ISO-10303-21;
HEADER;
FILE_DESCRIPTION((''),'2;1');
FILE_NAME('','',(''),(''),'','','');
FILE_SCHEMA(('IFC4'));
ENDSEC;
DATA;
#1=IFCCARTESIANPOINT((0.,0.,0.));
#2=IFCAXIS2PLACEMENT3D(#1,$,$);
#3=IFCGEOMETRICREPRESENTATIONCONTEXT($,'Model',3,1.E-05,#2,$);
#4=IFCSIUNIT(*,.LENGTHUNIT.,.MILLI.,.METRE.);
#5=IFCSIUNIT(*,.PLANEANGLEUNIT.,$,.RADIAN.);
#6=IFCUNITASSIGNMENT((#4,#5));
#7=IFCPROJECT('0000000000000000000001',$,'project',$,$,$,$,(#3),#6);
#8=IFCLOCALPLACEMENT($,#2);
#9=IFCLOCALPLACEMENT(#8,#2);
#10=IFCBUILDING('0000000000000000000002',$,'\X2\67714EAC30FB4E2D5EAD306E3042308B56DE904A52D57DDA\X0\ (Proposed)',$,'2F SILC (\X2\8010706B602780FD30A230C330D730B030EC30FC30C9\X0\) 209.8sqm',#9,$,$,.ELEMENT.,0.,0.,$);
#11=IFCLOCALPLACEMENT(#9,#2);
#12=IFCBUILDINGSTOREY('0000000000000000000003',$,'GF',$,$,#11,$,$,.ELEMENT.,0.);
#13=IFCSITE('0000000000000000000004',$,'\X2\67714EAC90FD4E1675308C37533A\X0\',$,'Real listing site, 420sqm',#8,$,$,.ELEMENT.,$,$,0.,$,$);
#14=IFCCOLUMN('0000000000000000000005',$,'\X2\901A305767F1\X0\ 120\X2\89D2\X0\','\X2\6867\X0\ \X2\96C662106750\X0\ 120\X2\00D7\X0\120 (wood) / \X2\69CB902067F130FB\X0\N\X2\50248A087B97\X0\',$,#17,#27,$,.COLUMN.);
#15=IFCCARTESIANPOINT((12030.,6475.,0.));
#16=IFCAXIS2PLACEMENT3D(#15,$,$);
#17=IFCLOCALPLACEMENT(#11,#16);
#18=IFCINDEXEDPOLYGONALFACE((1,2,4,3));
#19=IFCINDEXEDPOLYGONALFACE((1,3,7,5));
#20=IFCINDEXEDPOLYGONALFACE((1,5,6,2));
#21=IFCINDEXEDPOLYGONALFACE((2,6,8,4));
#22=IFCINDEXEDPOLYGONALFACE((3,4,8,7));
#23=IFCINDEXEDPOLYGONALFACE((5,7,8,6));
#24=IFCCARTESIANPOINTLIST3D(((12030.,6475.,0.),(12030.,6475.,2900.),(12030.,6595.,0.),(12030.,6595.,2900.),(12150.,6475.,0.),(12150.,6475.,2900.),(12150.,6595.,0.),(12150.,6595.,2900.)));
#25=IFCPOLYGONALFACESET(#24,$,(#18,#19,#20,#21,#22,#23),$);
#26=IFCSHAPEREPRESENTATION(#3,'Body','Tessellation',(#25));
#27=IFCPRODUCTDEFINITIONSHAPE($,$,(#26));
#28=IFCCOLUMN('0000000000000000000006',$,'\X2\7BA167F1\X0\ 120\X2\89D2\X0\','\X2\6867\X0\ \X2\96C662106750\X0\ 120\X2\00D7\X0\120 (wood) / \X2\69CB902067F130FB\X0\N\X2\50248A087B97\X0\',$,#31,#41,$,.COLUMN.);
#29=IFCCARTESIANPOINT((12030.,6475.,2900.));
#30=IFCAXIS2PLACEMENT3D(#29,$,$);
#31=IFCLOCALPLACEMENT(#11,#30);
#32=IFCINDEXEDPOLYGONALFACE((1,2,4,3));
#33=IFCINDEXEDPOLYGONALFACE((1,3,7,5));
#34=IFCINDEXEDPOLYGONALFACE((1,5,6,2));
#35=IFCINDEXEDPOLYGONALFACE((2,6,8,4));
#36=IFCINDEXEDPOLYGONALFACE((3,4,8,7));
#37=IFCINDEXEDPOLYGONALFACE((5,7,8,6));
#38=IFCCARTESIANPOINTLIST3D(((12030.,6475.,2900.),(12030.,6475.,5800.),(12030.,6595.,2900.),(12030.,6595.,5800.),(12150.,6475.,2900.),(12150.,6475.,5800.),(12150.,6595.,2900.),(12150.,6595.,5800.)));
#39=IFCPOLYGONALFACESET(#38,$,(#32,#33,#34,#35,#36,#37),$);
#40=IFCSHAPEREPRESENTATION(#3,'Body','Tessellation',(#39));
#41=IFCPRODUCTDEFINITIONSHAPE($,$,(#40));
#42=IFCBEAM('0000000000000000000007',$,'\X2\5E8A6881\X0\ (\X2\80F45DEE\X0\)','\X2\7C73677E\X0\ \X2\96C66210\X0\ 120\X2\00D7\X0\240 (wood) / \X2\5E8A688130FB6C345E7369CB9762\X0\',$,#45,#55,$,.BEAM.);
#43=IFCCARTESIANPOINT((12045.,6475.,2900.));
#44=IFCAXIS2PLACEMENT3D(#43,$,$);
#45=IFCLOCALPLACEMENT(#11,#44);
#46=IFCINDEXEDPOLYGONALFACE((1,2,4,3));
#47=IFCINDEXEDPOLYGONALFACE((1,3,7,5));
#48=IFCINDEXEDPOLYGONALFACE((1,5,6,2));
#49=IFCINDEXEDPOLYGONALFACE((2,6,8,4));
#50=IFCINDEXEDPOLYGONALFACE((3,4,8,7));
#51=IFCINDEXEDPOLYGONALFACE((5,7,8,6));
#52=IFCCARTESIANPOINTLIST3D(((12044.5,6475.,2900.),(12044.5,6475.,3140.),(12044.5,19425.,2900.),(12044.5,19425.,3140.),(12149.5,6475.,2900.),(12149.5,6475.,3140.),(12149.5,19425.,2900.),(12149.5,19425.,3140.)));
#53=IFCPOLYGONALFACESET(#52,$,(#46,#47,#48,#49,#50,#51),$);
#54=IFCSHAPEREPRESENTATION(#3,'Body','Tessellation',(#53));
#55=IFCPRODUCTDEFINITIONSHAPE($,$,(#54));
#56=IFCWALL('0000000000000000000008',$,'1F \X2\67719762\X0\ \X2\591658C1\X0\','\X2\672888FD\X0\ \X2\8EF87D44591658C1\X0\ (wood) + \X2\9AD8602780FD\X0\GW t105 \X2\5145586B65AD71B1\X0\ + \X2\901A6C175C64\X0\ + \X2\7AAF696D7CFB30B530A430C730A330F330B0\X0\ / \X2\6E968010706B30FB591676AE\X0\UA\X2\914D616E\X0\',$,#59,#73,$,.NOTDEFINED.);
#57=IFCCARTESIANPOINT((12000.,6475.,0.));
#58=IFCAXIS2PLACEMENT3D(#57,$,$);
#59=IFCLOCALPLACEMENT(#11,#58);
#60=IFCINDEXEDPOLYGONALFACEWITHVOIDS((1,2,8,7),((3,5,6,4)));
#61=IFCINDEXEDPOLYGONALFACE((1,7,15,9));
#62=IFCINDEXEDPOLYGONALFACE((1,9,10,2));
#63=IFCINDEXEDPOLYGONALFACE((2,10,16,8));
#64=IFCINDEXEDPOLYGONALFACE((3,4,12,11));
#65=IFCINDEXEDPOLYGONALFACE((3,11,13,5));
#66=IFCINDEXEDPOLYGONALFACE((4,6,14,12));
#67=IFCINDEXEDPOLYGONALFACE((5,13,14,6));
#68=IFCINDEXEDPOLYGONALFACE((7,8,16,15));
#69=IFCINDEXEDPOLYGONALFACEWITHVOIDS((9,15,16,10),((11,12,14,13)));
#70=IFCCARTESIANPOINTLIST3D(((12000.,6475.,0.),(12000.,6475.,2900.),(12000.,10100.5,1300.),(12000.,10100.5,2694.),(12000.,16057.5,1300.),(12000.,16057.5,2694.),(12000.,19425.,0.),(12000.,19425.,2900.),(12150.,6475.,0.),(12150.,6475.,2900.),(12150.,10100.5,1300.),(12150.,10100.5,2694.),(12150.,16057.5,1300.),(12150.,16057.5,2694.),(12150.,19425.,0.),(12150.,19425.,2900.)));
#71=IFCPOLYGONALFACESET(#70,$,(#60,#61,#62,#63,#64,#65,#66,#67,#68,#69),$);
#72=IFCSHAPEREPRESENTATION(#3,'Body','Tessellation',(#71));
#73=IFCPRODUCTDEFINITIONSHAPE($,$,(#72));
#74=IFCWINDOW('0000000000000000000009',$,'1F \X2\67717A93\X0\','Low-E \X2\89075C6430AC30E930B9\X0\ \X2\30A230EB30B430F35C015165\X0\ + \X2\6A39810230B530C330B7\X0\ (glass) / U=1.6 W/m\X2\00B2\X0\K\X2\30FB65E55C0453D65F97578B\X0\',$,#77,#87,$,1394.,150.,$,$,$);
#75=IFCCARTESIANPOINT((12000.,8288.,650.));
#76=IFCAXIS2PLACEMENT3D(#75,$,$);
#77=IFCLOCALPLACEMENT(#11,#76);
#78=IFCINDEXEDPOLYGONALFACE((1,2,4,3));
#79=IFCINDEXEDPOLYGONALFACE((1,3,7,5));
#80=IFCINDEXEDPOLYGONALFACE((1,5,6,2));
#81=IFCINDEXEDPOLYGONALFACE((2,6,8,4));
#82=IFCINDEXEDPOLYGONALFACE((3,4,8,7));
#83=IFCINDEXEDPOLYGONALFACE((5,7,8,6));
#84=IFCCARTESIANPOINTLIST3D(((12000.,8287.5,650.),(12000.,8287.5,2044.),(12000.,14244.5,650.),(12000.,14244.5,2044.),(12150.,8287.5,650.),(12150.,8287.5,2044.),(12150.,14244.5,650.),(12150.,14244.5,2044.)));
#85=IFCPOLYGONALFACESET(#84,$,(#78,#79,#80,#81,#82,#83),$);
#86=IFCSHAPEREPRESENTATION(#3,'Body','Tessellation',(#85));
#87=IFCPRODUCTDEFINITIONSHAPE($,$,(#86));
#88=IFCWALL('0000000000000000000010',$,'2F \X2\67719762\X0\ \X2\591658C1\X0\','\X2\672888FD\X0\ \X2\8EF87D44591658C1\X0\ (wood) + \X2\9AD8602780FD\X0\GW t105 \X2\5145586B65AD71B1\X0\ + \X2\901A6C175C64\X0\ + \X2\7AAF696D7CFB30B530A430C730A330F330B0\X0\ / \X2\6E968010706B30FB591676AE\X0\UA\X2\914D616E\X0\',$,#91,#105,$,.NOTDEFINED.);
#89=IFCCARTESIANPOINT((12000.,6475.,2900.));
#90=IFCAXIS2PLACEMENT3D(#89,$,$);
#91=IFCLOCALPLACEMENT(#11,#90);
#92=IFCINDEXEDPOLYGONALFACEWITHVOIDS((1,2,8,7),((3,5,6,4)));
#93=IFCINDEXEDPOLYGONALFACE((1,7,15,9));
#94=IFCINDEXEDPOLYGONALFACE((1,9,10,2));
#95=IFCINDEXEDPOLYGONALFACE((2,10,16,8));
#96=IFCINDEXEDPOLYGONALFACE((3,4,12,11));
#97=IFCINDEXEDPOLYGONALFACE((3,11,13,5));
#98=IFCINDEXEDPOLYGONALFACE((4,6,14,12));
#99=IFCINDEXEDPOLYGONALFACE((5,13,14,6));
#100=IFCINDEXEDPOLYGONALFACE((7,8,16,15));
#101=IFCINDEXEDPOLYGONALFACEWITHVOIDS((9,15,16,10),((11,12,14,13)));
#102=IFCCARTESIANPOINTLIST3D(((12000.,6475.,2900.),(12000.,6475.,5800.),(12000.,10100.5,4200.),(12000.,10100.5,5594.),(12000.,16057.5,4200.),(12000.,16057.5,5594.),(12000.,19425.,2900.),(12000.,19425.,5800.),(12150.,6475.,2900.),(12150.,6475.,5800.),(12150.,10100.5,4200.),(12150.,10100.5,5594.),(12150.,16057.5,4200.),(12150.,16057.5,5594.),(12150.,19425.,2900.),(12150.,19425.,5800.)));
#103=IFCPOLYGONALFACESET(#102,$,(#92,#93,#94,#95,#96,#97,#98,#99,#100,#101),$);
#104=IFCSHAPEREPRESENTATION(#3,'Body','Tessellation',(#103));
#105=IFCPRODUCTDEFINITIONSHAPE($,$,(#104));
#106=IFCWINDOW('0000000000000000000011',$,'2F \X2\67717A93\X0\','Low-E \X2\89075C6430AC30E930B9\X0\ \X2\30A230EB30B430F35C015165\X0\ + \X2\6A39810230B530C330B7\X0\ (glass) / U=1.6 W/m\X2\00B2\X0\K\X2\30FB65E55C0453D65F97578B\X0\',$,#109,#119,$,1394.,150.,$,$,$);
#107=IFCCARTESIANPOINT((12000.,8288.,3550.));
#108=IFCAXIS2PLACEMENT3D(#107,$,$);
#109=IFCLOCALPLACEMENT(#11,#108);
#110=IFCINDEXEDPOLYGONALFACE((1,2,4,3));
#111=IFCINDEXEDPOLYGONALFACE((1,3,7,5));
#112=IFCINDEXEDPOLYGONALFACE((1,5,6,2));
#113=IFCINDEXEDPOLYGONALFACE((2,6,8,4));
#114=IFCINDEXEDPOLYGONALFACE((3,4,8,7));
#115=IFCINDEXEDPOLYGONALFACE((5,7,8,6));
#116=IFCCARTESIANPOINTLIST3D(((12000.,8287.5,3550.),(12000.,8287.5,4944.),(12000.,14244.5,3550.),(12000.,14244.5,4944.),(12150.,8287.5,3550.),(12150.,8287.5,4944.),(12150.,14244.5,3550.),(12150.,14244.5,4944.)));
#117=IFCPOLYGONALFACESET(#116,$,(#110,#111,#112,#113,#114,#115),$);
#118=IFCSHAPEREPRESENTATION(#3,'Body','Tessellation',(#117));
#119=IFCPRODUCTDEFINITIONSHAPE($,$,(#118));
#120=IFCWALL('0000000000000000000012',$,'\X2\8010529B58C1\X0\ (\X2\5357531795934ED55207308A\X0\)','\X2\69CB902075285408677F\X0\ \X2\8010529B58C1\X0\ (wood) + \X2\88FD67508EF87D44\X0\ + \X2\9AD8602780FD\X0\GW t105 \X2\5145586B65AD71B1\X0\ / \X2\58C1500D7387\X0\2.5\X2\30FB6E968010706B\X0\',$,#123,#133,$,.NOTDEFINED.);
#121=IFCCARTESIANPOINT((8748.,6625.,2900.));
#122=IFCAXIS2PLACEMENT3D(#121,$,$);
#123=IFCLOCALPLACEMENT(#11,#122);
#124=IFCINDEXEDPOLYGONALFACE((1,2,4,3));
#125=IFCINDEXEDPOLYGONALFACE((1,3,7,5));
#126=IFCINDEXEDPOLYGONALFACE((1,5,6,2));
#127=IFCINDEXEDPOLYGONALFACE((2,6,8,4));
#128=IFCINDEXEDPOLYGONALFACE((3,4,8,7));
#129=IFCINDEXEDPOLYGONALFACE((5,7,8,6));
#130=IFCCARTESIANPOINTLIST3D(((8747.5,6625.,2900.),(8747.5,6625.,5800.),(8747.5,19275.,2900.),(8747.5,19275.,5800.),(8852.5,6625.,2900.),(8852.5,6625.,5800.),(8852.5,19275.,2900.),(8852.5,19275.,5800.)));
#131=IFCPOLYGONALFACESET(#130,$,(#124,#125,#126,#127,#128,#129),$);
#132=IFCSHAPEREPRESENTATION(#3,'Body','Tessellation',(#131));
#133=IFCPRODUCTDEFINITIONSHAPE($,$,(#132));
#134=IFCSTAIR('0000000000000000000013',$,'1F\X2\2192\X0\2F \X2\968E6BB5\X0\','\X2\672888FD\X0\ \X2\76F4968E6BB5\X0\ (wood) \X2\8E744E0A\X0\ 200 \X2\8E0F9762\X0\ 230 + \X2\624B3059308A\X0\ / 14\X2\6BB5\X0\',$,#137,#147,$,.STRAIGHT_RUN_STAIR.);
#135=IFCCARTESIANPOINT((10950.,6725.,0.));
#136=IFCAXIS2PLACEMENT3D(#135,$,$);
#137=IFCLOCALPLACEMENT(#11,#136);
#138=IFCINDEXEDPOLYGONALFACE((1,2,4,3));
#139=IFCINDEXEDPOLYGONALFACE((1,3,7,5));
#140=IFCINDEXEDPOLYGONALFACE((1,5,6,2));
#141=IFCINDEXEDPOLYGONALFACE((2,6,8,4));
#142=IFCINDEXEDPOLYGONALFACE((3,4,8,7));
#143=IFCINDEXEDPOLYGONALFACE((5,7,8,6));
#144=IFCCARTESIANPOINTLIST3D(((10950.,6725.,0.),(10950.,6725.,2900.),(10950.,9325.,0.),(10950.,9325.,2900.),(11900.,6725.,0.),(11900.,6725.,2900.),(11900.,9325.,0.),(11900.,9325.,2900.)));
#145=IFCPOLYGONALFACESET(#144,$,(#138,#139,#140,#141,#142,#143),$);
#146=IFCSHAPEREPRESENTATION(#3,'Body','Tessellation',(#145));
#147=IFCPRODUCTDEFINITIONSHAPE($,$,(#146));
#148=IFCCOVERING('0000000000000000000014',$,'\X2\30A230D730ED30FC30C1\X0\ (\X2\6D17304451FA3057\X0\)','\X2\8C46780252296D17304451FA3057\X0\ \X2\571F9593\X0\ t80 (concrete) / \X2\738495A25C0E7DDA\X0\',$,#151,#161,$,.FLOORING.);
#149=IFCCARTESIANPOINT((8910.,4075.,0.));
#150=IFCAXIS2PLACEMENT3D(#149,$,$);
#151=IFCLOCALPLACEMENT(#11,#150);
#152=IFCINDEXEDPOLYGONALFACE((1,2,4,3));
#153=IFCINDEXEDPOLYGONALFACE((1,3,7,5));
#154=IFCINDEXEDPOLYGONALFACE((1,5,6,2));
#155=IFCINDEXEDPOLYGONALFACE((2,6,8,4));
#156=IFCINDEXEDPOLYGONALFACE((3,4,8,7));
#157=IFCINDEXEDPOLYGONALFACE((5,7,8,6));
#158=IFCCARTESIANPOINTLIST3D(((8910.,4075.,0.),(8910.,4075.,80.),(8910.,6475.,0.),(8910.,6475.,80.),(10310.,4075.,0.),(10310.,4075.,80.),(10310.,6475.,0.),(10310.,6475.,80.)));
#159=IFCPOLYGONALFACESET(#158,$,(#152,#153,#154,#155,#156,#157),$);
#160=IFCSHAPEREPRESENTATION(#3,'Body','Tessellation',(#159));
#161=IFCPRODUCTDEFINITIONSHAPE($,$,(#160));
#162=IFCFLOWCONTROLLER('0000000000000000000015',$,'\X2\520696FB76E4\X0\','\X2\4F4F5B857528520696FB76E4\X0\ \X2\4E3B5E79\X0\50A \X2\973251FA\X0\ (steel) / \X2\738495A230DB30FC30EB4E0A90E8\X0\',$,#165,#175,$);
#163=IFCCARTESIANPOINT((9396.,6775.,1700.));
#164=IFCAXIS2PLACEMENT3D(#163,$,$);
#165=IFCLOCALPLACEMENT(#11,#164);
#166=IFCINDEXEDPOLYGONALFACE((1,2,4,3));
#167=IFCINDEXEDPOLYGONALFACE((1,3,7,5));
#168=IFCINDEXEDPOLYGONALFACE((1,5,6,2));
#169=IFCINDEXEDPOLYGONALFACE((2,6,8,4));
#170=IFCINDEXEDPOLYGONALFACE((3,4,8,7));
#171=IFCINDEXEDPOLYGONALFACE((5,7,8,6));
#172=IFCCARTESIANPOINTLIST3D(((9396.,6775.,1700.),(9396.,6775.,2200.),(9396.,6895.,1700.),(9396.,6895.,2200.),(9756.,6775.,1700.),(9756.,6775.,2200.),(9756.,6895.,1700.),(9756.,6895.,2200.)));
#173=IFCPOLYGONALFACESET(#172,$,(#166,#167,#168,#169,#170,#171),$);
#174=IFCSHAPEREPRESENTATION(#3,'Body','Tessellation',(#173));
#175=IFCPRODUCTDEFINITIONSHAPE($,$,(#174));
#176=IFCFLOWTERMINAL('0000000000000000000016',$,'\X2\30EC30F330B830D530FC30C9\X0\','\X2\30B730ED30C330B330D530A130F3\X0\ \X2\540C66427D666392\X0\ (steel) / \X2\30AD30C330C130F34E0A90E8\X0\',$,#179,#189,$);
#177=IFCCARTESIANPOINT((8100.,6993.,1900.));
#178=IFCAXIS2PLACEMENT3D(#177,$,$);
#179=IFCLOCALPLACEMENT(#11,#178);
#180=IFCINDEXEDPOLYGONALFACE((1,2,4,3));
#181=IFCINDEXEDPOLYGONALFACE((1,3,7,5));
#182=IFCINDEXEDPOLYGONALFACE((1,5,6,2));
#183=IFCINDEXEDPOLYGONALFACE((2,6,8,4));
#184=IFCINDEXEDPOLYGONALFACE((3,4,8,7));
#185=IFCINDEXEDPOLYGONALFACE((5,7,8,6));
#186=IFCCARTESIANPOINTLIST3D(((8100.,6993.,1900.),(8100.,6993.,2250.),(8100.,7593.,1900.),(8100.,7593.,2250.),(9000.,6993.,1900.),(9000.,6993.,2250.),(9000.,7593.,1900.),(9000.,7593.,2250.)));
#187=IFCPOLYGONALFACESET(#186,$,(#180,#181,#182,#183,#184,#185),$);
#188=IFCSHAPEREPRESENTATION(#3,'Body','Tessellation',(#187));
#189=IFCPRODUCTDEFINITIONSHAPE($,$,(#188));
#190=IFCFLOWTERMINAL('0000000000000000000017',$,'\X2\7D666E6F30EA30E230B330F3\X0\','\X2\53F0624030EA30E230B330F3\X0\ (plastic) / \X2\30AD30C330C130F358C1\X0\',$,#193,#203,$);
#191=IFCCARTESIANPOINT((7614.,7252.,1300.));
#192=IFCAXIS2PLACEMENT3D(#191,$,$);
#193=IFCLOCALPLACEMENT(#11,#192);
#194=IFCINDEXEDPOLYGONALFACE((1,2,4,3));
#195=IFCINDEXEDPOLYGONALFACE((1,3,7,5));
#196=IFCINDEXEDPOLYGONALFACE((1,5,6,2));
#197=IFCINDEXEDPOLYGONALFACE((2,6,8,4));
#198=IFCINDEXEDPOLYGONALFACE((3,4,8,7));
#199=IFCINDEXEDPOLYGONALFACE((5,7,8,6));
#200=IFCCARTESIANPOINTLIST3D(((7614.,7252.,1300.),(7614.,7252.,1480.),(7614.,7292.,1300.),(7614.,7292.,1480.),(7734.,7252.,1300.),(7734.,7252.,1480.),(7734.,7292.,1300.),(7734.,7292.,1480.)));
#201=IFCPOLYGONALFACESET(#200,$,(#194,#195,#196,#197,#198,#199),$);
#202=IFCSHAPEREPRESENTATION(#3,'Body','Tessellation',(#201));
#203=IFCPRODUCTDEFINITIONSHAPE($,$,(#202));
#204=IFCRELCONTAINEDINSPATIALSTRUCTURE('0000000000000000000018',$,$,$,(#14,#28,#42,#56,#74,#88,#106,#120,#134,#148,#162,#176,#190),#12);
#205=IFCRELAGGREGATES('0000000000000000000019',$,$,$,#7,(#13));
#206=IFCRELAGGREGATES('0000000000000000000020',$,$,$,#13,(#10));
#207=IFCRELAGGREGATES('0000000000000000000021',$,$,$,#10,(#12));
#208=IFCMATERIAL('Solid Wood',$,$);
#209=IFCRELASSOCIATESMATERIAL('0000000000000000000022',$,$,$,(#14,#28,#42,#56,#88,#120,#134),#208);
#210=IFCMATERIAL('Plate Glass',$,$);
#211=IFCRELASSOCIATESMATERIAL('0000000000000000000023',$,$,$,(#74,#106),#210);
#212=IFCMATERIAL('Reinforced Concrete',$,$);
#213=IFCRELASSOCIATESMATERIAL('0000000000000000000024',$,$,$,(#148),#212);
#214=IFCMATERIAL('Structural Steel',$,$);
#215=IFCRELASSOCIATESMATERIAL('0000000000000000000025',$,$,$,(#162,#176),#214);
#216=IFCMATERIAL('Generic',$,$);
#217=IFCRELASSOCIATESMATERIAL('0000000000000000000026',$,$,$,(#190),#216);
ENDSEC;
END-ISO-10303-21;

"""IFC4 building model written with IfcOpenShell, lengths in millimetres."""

from ifc_helpers import new_model, si_unit, frame, frame_2d, origin, place, context, project, spatial, rectangle, extrude, material, element, fill, save


model = new_model("IFC4")

# Units and contexts
model_context = context("Model", 3, precision=1e-05, world=origin())
ifc_project = project(units=[si_unit("LENGTHUNIT", "METRE", prefix="MILLI"), si_unit("PLANEANGLEUNIT", "RADIAN")], contexts=[model_context])

# Site, building, storey
site_placement = place(None, origin())
site = spatial("IfcSite", under=ifc_project, at=site_placement, Name="東京都世田谷区", ObjectType="Real listing site, 420sqm", CompositionType="ELEMENT", RefElevation=0.0)
building_placement = place(site_placement, origin())
building = spatial("IfcBuilding", under=site, at=building_placement, Name="東京・中庭のある回遊動線 (Proposed)", ObjectType="2F SILC (耐火性能アップグレード) 209.8sqm", CompositionType="ELEMENT", ElevationOfRefHeight=0.0, ElevationOfTerrain=0.0)
storey_placement = place(building_placement, origin())
storey = spatial("IfcBuildingStorey", under=building, at=storey_placement, Name="GF", CompositionType="ELEMENT", Elevation=0.0)

# Columns
ifc_material_1 = material(Name="Solid Wood")
column_1_placement = place(storey_placement, frame((12030.0, 6475.0, 0.0)))
element("IfcColumn", 1, at=column_1_placement, inside=storey, material=ifc_material_1, Name="通し柱 120角", Description="桧 集成材 120×120 (wood) / 構造柱・N値計算", PredefinedType="COLUMN", context=model_context, shape_type="SweptSolid", body=[
    extrude(rectangle(XDim=120.0, YDim=120.0, at=frame_2d((60.0, 60.0))), frame((12030.0, 6475.0, 0.0)), (0.0, 0.0, 1.0), 2900.0),
])
column_2_placement = place(storey_placement, frame((12030.0, 6475.0, 2900.0)))
element("IfcColumn", 2, at=column_2_placement, inside=storey, material=ifc_material_1, Name="管柱 120角", Description="桧 集成材 120×120 (wood) / 構造柱・N値計算", PredefinedType="COLUMN", context=model_context, shape_type="SweptSolid", body=[
    extrude(rectangle(XDim=120.0, YDim=120.0, at=frame_2d((60.0, 60.0))), frame((12030.0, 6475.0, 2900.0)), (0.0, 0.0, 1.0), 2900.0),
])

# Beam
beam_1_placement = place(storey_placement, frame((12045.0, 6475.0, 2900.0)))
element("IfcBeam", 3, at=beam_1_placement, inside=storey, material=ifc_material_1, Name="床梁 (胴差)", Description="米松 集成 120×240 (wood) / 床梁・水平構面", PredefinedType="BEAM", context=model_context, shape_type="SweptSolid", body=[
    extrude(rectangle(XDim=105.0, YDim=12950.0, at=frame_2d((52.0, 6475.0))), frame((12045.0, 6475.0, 2900.0)), (0.0, 0.0, 1.0), 240.0),
])

# Wall, opening, window
wall_1_placement = place(storey_placement, frame((12000.0, 6475.0, 0.0)))
wall_1 = element("IfcWall", 4, at=wall_1_placement, inside=storey, material=ifc_material_1, Name="1F 東面 外壁", Description="木製 軸組外壁 (wood) + 高性能GW t105 充填断熱 + 通気層 + 窯業系サイディング / 準耐火・外皮UA配慮", PredefinedType="NOTDEFINED", context=model_context, shape_type="SweptSolid", body=[
    extrude(rectangle(XDim=150.0, YDim=12950.0, at=frame_2d((75.0, 6475.0))), frame((12000.0, 6475.0, 0.0)), (0.0, 0.0, 1.0), 2900.0),
])
opening_1_placement = place(storey_placement, frame((12000.0, 8288.0, 650.0)))
opening_1 = element("IfcOpeningElement", 5, at=opening_1_placement, cuts=wall_1, PredefinedType="NOTDEFINED", context=model_context, shape_type="SweptSolid", body=[
    extrude(rectangle(XDim=150.0, YDim=5957.0, at=frame_2d((75.0, 2978.0))), frame((12000.0, 8288.0, 650.0)), (0.0, 0.0, 1.0), 1394.0),
])
ifc_material_2 = material(Name="Plate Glass")
window_1_placement = place(storey_placement, frame((12000.0, 8288.0, 650.0)))
window_1 = element("IfcWindow", 6, at=window_1_placement, inside=storey, material=ifc_material_2, Name="1F 東窓", Description="Low-E 複層ガラス アルゴン封入 + 樹脂サッシ (glass) / U=1.6 W/m²K・日射取得型", OverallHeight=1394.0, OverallWidth=150.0, context=model_context, shape_type="SweptSolid", body=[
    extrude(rectangle(XDim=150.0, YDim=5957.0, at=frame_2d((75.0, 2978.0))), frame((12000.0, 8288.0, 650.0)), (0.0, 0.0, 1.0), 1394.0),
])
fill(opening_1, window_1)

# Wall, opening, window
wall_2_placement = place(storey_placement, frame((12000.0, 6475.0, 2900.0)))
wall_2 = element("IfcWall", 7, at=wall_2_placement, inside=storey, material=ifc_material_1, Name="2F 東面 外壁", Description="木製 軸組外壁 (wood) + 高性能GW t105 充填断熱 + 通気層 + 窯業系サイディング / 準耐火・外皮UA配慮", PredefinedType="NOTDEFINED", context=model_context, shape_type="SweptSolid", body=[
    extrude(rectangle(XDim=150.0, YDim=12950.0, at=frame_2d((75.0, 6475.0))), frame((12000.0, 6475.0, 2900.0)), (0.0, 0.0, 1.0), 2900.0),
])
opening_2_placement = place(storey_placement, frame((12000.0, 8288.0, 3550.0)))
opening_2 = element("IfcOpeningElement", 8, at=opening_2_placement, cuts=wall_2, PredefinedType="NOTDEFINED", context=model_context, shape_type="SweptSolid", body=[
    extrude(rectangle(XDim=150.0, YDim=5957.0, at=frame_2d((75.0, 2978.0))), frame((12000.0, 8288.0, 3550.0)), (0.0, 0.0, 1.0), 1394.0),
])
window_2_placement = place(storey_placement, frame((12000.0, 8288.0, 3550.0)))
window_2 = element("IfcWindow", 9, at=window_2_placement, inside=storey, material=ifc_material_2, Name="2F 東窓", Description="Low-E 複層ガラス アルゴン封入 + 樹脂サッシ (glass) / U=1.6 W/m²K・日射取得型", OverallHeight=1394.0, OverallWidth=150.0, context=model_context, shape_type="SweptSolid", body=[
    extrude(rectangle(XDim=150.0, YDim=5957.0, at=frame_2d((75.0, 2978.0))), frame((12000.0, 8288.0, 3550.0)), (0.0, 0.0, 1.0), 1394.0),
])
fill(opening_2, window_2)

# Wall
wall_3_placement = place(storey_placement, frame((8748.0, 6625.0, 2900.0)))
element("IfcWall", 10, at=wall_3_placement, inside=storey, material=ifc_material_1, Name="耐力壁 (南北間仕切り)", Description="構造用合板 耐力壁 (wood) + 製材軸組 + 高性能GW t105 充填断熱 / 壁倍率2.5・準耐火", PredefinedType="NOTDEFINED", context=model_context, shape_type="SweptSolid", body=[
    extrude(rectangle(XDim=105.0, YDim=12650.0, at=frame_2d((52.0, 6325.0))), frame((8748.0, 6625.0, 2900.0)), (0.0, 0.0, 1.0), 2900.0),
])

# Stair
stair_placement = place(storey_placement, frame((10950.0, 6725.0, 0.0)))
element("IfcStair", 11, at=stair_placement, inside=storey, material=ifc_material_1, Name="1F→2F 階段", Description="木製 直階段 (wood) 蹴上 200 踏面 230 + 手すり / 14段", PredefinedType="STRAIGHT_RUN_STAIR", context=model_context, shape_type="SweptSolid", body=[
    extrude(rectangle(XDim=950.0, YDim=2600.0, at=frame_2d((475.0, 1300.0))), frame((10950.0, 6725.0, 0.0)), (0.0, 0.0, 1.0), 2900.0),
])

# Covering
ifc_material_3 = material(Name="Reinforced Concrete")
covering_placement = place(storey_placement, frame((8910.0, 4075.0, 0.0)))
element("IfcCovering", 12, at=covering_placement, inside=storey, material=ifc_material_3, Name="アプローチ (洗い出し)", Description="豆砂利洗い出し 土間 t80 (concrete) / 玄関導線", PredefinedType="FLOORING", context=model_context, shape_type="SweptSolid", body=[
    extrude(rectangle(XDim=1400.0, YDim=2400.0, at=frame_2d((700.0, 1200.0))), frame((8910.0, 4075.0, 0.0)), (0.0, 0.0, 1.0), 80.0),
])

# Flow controller
ifc_material_4 = material(Name="Structural Steel")
flow_controller_placement = place(storey_placement, frame((9396.0, 6775.0, 1700.0)))
element("IfcFlowController", 13, at=flow_controller_placement, inside=storey, material=ifc_material_4, Name="分電盤", Description="住宅用分電盤 主幹50A 露出 (steel) / 玄関ホール上部", context=model_context, shape_type="SweptSolid", body=[
    extrude(rectangle(XDim=360.0, YDim=120.0, at=frame_2d((180.0, 60.0))), frame((9396.0, 6775.0, 1700.0)), (0.0, 0.0, 1.0), 500.0),
])

# Flow terminals
flow_terminal_1_placement = place(storey_placement, frame((8100.0, 6993.0, 1900.0)))
element("IfcFlowTerminal", 14, at=flow_terminal_1_placement, inside=storey, material=ifc_material_4, Name="レンジフード", Description="シロッコファン 同時給排 (steel) / キッチン上部", context=model_context, shape_type="SweptSolid", body=[
    extrude(rectangle(XDim=900.0, YDim=600.0, at=frame_2d((450.0, 300.0))), frame((8100.0, 6993.0, 1900.0)), (0.0, 0.0, 1.0), 350.0),
])
ifc_material_5 = material(Name="Generic")
flow_terminal_2_placement = place(storey_placement, frame((7614.0, 7252.0, 1300.0)))
element("IfcFlowTerminal", 15, at=flow_terminal_2_placement, inside=storey, material=ifc_material_5, Name="給湯リモコン", Description="台所リモコン (plastic) / キッチン壁", context=model_context, shape_type="SweptSolid", body=[
    extrude(rectangle(XDim=120.0, YDim=40.0, at=frame_2d((60.0, 20.0))), frame((7614.0, 7252.0, 1300.0)), (0.0, 0.0, 1.0), 180.0),
])

save(model, "model.ifc")
